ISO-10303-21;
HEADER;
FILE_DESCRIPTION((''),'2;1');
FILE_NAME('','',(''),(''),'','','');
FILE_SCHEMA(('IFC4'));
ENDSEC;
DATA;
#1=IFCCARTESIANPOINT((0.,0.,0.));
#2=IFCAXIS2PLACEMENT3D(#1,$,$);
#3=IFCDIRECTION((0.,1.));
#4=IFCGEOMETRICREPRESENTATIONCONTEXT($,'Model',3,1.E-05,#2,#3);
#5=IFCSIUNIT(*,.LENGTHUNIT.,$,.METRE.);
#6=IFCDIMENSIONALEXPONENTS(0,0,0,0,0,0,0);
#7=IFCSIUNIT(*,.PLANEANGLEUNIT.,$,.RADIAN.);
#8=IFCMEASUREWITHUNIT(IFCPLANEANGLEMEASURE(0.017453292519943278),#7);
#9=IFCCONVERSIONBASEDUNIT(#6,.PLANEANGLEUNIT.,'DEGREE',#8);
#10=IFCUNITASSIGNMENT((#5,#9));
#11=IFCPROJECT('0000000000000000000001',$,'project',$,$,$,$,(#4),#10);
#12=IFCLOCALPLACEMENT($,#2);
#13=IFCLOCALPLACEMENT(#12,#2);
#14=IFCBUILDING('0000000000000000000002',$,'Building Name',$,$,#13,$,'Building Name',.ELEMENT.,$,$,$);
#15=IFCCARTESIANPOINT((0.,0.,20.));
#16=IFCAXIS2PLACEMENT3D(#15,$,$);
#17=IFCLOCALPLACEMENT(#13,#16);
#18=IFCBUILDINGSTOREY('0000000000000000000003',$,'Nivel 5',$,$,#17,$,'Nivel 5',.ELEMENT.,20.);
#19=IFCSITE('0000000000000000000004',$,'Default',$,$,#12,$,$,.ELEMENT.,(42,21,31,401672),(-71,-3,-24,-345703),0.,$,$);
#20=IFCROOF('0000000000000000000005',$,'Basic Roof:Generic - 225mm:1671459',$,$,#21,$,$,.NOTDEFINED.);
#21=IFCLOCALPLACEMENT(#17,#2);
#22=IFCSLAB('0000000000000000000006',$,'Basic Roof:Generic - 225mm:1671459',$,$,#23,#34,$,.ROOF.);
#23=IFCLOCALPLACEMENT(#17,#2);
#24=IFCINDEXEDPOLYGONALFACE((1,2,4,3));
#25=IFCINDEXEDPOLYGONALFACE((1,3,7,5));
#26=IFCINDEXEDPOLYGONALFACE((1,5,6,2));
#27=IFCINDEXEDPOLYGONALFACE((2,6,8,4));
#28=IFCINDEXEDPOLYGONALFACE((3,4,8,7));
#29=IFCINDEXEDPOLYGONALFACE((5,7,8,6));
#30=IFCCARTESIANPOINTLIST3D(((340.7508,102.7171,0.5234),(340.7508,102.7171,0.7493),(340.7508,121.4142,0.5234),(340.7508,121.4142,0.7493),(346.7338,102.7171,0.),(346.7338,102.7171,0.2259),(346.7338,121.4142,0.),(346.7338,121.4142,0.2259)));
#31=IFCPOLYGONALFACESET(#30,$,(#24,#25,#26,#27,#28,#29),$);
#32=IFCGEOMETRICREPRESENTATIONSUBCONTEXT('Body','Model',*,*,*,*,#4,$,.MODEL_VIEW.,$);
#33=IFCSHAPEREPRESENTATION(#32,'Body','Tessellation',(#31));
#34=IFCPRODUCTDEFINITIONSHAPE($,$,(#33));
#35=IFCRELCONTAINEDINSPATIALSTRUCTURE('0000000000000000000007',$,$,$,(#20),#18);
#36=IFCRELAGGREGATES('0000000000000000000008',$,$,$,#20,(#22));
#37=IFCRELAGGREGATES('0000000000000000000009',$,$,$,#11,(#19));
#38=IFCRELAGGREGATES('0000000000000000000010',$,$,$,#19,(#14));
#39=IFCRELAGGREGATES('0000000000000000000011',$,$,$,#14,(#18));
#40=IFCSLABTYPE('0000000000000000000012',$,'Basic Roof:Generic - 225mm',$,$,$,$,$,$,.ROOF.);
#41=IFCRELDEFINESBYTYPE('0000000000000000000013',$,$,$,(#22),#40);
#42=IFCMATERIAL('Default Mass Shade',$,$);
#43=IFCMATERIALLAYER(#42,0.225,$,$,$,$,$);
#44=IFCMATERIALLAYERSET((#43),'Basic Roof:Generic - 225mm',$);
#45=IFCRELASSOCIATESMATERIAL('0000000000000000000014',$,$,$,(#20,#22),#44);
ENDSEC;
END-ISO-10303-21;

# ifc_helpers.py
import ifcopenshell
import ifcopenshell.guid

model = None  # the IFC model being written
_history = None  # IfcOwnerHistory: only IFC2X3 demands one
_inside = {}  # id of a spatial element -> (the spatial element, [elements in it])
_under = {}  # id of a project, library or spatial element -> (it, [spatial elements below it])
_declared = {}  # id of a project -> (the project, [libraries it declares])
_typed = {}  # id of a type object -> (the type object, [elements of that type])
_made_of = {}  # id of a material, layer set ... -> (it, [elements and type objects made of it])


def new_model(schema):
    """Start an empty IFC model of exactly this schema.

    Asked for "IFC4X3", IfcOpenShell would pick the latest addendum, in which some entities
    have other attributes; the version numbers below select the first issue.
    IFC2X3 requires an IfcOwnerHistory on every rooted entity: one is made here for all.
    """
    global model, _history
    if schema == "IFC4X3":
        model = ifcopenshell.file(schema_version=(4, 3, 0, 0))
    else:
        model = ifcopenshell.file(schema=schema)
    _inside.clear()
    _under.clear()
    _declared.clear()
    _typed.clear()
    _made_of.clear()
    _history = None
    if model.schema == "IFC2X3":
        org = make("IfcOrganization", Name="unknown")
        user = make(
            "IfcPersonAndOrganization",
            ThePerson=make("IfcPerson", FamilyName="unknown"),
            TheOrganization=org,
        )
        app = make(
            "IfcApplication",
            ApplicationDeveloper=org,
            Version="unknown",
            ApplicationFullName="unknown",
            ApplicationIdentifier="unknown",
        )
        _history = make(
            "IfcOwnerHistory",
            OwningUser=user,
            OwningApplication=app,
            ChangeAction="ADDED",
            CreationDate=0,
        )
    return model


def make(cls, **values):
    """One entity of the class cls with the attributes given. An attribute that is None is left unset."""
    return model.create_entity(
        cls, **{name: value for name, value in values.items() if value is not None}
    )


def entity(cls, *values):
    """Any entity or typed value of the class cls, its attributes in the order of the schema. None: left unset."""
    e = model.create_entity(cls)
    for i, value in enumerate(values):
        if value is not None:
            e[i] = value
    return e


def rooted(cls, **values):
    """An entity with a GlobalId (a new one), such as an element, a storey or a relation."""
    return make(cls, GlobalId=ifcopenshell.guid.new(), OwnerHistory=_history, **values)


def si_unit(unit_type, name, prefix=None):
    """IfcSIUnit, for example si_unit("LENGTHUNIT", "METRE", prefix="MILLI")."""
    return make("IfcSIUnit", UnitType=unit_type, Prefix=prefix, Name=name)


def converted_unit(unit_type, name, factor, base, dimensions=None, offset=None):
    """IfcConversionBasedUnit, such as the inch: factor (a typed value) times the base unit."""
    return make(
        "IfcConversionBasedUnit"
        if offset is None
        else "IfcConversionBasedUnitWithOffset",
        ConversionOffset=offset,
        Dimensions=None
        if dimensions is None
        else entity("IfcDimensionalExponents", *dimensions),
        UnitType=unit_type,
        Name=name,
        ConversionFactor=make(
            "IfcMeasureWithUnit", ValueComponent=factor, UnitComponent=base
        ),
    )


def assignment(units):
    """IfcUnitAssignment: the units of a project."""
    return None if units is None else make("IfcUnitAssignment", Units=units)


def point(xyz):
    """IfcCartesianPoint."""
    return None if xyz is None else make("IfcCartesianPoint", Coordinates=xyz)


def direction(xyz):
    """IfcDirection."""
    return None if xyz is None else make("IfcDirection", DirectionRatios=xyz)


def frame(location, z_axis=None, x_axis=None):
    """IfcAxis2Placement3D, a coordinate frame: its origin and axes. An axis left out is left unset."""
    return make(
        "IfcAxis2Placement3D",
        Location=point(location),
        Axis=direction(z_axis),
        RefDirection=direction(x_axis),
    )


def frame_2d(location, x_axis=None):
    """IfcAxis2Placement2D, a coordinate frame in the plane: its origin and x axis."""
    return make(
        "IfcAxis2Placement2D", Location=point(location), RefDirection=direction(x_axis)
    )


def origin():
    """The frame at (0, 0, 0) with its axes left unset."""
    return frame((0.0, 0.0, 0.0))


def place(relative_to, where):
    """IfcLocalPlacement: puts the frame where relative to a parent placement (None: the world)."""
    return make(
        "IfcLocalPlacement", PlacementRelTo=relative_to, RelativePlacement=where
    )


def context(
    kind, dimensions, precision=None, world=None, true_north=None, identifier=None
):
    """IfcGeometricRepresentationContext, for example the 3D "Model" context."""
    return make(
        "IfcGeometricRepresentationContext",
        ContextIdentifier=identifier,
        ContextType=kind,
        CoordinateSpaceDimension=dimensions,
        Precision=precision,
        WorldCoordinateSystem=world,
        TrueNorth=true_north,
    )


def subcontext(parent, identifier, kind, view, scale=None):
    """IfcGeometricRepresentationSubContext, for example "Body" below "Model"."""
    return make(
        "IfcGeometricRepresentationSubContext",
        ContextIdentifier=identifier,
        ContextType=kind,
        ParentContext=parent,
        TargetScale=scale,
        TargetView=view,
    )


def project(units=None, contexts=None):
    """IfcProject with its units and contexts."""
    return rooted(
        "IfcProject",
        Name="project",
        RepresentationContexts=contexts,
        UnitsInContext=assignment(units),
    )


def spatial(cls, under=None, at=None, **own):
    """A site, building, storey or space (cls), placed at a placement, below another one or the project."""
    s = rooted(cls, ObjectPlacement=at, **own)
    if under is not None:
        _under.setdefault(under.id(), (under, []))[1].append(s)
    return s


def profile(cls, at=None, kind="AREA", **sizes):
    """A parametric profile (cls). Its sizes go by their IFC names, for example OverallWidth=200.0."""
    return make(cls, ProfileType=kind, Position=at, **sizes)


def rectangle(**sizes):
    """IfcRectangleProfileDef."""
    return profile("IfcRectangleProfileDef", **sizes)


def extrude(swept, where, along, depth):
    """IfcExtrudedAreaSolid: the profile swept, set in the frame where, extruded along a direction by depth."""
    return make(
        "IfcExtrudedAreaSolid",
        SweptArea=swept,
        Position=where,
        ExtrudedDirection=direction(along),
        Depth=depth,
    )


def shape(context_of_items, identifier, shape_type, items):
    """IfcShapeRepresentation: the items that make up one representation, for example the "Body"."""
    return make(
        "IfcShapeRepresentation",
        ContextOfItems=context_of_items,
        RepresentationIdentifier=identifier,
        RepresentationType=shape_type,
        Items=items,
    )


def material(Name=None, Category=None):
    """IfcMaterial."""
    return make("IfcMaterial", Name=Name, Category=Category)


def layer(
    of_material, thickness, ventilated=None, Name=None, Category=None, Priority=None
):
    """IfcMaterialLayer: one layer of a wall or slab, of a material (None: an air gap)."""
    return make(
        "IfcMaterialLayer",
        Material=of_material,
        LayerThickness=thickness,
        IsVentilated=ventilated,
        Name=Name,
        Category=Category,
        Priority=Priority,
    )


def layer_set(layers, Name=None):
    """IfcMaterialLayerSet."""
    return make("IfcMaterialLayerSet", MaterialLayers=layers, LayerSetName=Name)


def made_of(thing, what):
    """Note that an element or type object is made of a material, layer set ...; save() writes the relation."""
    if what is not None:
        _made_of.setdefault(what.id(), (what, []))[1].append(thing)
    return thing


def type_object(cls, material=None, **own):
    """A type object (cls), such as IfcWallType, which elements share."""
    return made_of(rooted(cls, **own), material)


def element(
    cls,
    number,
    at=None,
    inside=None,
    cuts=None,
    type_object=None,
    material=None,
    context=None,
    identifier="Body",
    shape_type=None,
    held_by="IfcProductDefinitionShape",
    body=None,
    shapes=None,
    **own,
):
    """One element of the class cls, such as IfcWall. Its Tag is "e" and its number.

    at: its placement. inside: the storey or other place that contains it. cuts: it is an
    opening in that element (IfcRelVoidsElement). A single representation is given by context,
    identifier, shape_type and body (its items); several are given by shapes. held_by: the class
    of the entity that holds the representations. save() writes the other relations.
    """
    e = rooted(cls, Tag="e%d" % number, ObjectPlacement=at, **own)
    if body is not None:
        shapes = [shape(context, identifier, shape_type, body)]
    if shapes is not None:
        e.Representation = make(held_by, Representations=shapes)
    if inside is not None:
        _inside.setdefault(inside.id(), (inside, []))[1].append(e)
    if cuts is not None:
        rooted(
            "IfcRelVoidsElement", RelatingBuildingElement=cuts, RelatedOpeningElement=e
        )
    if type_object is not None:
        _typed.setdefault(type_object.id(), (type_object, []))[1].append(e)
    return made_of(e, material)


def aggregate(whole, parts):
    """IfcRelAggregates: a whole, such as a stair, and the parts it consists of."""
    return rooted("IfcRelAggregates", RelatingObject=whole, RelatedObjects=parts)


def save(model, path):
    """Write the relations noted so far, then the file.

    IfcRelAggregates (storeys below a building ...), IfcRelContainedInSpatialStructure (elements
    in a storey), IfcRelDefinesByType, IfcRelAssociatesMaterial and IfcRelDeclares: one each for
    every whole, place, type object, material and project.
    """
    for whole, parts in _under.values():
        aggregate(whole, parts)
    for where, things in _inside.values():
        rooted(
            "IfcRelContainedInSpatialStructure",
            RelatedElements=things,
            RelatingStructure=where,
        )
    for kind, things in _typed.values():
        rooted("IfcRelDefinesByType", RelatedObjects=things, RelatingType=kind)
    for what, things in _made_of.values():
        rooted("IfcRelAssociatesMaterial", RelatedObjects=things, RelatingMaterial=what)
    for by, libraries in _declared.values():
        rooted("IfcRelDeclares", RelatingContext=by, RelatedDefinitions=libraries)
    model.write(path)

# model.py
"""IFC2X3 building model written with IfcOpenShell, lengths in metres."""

from ifc_helpers import new_model, entity, si_unit, converted_unit, direction, frame, frame_2d, origin, place, context, subcontext, project, spatial, rectangle, extrude, material, layer, layer_set, type_object, element, aggregate, save


model = new_model("IFC2X3")

# Units and contexts
model_context = context("Model", 3, precision=1e-05, world=origin(), true_north=direction((0.0, 1.0)))
body_context = subcontext(model_context, "Body", "Model", "MODEL_VIEW")
ifc_project = project(units=[si_unit("LENGTHUNIT", "METRE"), converted_unit("PLANEANGLEUNIT", "DEGREE", entity("IfcPlaneAngleMeasure", 0.017453292519943278), si_unit("PLANEANGLEUNIT", "RADIAN"), dimensions=[0, 0, 0, 0, 0, 0, 0])], contexts=[model_context])

# Site, building, storey
site_placement = place(None, origin())
site = spatial("IfcSite", under=ifc_project, at=site_placement, Name="Default", CompositionType="ELEMENT", RefLatitude=(42, 21, 31, 401672), RefLongitude=(-71, -3, -24, -345703), RefElevation=0.0)
building_placement = place(site_placement, origin())
building = spatial("IfcBuilding", under=site, at=building_placement, Name="Building Name", LongName="Building Name", CompositionType="ELEMENT")
storey_placement = place(building_placement, frame((0.0, 0.0, 20.0)))
storey = spatial("IfcBuildingStorey", under=building, at=storey_placement, Name="Nivel 5", LongName="Nivel 5", CompositionType="ELEMENT", Elevation=20.0)

# Roof, slab
ifc_material = material(Name="Default Mass Shade")
ifc_layer = layer(ifc_material, 0.225)
ifc_layer_set = layer_set([ifc_layer], Name="Basic Roof:Generic - 225mm")
roof_placement = place(storey_placement, frame((340.7508, 102.7171, 0.0)))
roof = element("IfcRoof", 1, at=roof_placement, inside=storey, material=ifc_layer_set, Name="Basic Roof:Generic - 225mm:1671459", ShapeType="NOTDEFINED")
slab_type = type_object("IfcSlabType", Name="Basic Roof:Generic - 225mm", PredefinedType="ROOF")
slab_placement = place(roof_placement, origin())
slab = element("IfcSlab", 2, at=slab_placement, type_object=slab_type, material=ifc_layer_set, Name="Basic Roof:Generic - 225mm:1671459", PredefinedType="ROOF", context=body_context, shape_type="SweptSolid", body=[
    extrude(rectangle(XDim=18.6971, YDim=6.0059, at=frame_2d((0.0, 0.0), x_axis=(0.0, 1.0))), frame((2.9915, 9.3486, 0.2617), z_axis=(0.087156, 0.0, 0.996195), x_axis=(0.996195, 0.0, -0.087156)), (-0.087156, 0.0, 0.996195), 0.2259),
])
aggregate(roof, [slab])

save(model, "model.ifc")
